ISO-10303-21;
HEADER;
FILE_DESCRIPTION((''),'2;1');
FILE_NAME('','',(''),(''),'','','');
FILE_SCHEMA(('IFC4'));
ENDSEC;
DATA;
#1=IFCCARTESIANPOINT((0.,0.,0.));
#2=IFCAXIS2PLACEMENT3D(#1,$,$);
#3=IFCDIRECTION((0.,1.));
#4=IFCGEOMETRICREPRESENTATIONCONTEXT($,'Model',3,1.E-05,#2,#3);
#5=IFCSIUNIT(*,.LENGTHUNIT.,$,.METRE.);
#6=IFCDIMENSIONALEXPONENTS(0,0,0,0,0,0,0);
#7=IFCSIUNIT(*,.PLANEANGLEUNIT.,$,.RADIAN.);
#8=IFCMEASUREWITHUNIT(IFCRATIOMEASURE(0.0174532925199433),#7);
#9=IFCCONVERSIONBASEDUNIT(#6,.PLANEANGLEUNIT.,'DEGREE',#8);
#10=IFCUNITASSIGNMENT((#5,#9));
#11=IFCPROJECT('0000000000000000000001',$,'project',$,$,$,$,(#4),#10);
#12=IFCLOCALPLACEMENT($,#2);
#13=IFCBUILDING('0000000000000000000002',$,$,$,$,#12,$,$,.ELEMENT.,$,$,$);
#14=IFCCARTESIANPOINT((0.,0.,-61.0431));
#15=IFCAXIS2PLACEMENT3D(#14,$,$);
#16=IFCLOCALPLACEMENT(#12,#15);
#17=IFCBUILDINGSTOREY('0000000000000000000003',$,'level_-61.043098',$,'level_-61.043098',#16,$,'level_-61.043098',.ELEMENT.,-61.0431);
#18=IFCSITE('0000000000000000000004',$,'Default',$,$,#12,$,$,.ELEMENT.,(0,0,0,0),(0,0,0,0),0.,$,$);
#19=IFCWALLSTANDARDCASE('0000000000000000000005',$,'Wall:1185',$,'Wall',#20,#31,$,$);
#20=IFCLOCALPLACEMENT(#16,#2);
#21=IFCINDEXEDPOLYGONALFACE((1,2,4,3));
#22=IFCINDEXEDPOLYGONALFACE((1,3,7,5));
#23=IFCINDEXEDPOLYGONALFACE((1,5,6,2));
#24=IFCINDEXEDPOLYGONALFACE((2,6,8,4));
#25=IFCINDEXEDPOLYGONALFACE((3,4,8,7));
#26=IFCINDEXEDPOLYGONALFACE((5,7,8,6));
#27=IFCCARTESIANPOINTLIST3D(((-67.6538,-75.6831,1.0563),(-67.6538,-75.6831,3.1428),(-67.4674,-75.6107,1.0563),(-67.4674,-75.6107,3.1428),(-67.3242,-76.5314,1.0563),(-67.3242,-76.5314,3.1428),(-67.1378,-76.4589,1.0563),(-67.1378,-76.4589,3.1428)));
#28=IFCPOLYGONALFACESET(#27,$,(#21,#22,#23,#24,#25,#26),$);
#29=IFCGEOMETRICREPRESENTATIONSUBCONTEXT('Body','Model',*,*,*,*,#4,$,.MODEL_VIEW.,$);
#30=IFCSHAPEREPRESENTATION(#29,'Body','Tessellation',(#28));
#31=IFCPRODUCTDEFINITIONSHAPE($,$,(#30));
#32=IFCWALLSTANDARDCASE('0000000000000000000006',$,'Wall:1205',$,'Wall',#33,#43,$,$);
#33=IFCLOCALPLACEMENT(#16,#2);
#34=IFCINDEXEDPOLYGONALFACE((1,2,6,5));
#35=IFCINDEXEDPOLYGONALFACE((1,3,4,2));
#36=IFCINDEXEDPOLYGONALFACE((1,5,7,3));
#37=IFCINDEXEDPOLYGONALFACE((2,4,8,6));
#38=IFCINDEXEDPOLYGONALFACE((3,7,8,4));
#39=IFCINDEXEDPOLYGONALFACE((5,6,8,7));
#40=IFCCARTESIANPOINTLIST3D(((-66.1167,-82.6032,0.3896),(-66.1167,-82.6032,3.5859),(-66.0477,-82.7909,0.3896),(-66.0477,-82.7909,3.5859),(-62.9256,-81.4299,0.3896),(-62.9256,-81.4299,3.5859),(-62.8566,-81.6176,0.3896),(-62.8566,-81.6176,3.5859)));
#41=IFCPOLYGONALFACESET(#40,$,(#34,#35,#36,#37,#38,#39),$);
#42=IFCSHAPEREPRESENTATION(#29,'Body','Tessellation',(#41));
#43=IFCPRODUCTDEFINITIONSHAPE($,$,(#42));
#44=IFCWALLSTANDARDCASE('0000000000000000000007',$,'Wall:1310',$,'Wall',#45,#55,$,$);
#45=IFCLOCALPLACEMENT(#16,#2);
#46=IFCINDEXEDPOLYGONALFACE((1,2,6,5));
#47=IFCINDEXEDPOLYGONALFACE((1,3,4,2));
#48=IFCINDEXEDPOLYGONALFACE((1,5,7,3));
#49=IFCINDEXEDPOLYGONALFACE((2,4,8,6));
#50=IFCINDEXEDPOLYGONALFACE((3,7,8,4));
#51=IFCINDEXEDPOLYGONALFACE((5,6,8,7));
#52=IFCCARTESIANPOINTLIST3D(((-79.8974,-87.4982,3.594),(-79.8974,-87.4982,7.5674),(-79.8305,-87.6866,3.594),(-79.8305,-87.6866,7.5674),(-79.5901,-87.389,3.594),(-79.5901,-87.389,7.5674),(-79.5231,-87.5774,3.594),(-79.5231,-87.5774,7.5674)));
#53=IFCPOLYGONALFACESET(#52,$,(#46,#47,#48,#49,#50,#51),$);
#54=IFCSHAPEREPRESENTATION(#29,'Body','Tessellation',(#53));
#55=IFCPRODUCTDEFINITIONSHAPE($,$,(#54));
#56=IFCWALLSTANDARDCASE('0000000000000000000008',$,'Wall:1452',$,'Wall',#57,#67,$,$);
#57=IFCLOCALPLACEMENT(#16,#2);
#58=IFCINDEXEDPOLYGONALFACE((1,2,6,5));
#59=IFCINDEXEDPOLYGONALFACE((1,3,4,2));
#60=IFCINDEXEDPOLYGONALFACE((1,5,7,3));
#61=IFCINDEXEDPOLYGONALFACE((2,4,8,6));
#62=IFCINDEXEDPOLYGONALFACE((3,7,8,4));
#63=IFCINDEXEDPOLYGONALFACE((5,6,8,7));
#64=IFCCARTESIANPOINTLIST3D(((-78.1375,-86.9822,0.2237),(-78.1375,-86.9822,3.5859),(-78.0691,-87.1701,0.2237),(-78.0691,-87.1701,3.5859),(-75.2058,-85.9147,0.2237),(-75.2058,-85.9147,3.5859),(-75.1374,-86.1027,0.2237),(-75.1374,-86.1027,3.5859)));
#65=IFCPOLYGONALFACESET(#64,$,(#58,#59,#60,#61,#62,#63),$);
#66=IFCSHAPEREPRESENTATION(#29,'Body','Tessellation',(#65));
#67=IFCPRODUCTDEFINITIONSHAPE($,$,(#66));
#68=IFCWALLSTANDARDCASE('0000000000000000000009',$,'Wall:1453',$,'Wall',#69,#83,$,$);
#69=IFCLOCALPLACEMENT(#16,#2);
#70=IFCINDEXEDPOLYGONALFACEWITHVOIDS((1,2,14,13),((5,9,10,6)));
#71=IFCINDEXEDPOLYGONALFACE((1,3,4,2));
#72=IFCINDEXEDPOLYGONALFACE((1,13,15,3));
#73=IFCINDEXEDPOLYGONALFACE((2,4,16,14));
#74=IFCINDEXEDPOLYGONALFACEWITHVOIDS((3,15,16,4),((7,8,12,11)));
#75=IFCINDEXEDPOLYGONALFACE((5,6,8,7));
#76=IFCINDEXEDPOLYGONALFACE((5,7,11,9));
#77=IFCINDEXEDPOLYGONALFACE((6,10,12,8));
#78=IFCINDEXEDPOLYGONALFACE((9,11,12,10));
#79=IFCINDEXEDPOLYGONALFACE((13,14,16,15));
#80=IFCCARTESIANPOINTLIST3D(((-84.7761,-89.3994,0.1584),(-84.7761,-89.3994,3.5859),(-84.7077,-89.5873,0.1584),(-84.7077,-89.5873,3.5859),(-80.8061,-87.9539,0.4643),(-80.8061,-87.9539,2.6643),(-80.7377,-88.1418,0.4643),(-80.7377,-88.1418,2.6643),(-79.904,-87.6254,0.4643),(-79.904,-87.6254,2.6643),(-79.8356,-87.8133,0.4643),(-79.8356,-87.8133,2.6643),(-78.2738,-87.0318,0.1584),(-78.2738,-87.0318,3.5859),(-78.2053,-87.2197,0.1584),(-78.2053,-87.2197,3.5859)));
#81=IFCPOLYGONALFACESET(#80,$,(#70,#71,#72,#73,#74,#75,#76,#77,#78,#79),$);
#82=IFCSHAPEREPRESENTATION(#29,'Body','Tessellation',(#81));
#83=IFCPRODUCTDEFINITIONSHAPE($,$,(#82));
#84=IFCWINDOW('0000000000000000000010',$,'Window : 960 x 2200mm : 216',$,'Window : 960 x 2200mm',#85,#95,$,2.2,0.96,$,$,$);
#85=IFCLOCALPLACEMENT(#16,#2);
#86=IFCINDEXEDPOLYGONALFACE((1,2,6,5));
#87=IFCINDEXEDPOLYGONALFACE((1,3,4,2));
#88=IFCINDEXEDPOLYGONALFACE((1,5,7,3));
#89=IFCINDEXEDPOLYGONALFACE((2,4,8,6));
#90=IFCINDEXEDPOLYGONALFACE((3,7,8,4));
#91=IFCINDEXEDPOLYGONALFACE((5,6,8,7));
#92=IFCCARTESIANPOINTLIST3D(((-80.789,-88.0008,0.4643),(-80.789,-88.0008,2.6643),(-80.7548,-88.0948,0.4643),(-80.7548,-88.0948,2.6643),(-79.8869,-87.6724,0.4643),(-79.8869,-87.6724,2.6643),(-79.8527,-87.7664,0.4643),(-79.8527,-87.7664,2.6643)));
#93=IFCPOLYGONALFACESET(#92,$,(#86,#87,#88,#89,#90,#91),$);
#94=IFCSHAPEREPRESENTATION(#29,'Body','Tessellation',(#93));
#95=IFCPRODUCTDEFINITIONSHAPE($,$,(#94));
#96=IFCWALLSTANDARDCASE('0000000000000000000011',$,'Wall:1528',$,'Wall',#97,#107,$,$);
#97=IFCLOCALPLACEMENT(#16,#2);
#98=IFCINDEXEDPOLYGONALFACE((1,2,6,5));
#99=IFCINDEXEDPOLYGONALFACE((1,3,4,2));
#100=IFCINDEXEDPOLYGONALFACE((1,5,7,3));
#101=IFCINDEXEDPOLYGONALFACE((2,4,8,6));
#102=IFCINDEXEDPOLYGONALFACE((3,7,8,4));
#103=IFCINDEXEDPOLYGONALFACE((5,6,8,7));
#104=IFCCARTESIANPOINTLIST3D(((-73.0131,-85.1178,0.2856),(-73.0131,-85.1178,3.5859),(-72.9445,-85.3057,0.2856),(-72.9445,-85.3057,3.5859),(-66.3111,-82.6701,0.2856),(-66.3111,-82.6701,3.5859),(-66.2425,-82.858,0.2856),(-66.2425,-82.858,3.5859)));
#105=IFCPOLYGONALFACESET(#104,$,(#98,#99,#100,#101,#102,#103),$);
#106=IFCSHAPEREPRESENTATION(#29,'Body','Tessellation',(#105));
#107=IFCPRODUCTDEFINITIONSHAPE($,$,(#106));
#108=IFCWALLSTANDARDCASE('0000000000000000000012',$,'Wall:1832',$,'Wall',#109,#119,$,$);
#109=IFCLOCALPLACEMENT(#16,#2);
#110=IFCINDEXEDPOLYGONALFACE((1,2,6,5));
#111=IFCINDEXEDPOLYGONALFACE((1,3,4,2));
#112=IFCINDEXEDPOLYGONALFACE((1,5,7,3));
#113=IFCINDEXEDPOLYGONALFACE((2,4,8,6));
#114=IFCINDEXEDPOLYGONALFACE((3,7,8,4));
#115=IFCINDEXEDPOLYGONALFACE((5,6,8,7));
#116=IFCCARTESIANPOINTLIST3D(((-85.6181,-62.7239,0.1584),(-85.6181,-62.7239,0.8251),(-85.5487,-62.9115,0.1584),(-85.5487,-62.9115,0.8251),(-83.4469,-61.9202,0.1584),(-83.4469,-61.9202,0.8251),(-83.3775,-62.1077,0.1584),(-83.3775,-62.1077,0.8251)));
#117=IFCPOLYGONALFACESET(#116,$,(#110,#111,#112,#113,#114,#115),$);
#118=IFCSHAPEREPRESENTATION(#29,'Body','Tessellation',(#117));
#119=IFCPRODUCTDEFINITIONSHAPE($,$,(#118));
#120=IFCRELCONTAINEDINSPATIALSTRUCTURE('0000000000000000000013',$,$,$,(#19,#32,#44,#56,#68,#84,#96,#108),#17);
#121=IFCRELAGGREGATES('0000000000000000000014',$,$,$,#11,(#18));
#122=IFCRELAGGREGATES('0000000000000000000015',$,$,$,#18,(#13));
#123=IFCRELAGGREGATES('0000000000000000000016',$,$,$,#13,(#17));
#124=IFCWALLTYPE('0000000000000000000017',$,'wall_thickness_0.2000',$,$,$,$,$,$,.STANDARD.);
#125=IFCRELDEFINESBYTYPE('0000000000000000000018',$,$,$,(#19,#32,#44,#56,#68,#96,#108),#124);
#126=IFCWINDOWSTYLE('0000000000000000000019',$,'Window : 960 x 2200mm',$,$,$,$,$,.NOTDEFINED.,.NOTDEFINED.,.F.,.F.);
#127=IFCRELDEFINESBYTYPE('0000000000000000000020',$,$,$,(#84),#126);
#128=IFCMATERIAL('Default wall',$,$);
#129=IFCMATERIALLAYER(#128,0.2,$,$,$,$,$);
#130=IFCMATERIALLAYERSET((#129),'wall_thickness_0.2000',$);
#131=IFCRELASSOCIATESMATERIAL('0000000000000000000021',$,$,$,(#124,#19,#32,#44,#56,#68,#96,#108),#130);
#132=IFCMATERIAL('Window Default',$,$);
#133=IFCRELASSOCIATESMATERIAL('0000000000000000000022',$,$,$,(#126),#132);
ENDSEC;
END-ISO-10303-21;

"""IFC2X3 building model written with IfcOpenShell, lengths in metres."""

from ifc_helpers import new_model, entity, si_unit, converted_unit, direction, frame, frame_2d, origin, origin_2d_with_axis, place, context, subcontext, project, spatial, polyline, rectangle, outline, extrude, source, transform, mapped, material, layer, layer_set, layer_usage, type_object, type_shapes, element, fill, save


model = new_model("IFC2X3")

# Units and contexts
model_context = context("Model", 3, precision=1e-05, world=origin(), true_north=direction((0.0, 1.0)))
body_context = subcontext(model_context, "Body", "Model", "MODEL_VIEW")
ifc_project = project(units=[si_unit("LENGTHUNIT", "METRE"), converted_unit("PLANEANGLEUNIT", "DEGREE", entity("IfcRatioMeasure", 0.0174532925199433), si_unit("PLANEANGLEUNIT", "RADIAN"), dimensions=[0, 0, 0, 0, 0, 0, 0])], contexts=[model_context])

# Site, building, storey
placement_1 = place(None, origin())
site = spatial("IfcSite", under=ifc_project, at=placement_1, Name="Default", CompositionType="ELEMENT", RefLatitude=(0, 0, 0, 0), RefLongitude=(0, 0, 0, 0), RefElevation=0.0)
building = spatial("IfcBuilding", under=site, at=placement_1, CompositionType="ELEMENT")
storey_placement = place(placement_1, frame((0.0, 0.0, -61.0431)))
storey = spatial("IfcBuildingStorey", under=building, at=storey_placement, Name="level_-61.043098", ObjectType="level_-61.043098", LongName="level_-61.043098", CompositionType="ELEMENT", Elevation=-61.0431)

# Shared definitions
ifc_material_1 = material(Name="Default wall")
ifc_layer = layer(ifc_material_1, 0.2)
ifc_layer_set = layer_set([ifc_layer], Name="wall_thickness_0.2000")
ifc_layer_usage = layer_usage(ifc_layer_set, "AXIS2", "POSITIVE", -0.1)
wall_type = type_object("IfcWallType", Name="wall_thickness_0.2000", PredefinedType="STANDARD", material=ifc_layer_set)

# Shared definitions
ifc_material_2 = material(Name="Window Default")

# Walls
placement_2 = place(placement_1, frame((0.0, 0.0, -59.9868)))
wall_1_placement = place(placement_2, frame((-67.231, -76.4951, 0.0), z_axis=(0.0, 0.0, 1.0), x_axis=(-0.36216, 0.932116, 0.0)))
element("IfcWallStandardCase", 1, at=wall_1_placement, inside=storey, type_object=wall_type, material=ifc_layer_usage, Name="Wall:1185", ObjectType="Wall", context=body_context, shape_type="SweptSolid", body=[
    extrude(outline(polyline([(0.91, -0.1), (0.91, 0.1), (0.0, 0.1), (0.0, -0.1), (0.91, -0.1)])), origin(), (0.0, 0.0, 1.0), 2.0865),
])
placement_3 = place(placement_1, frame((0.0, 0.0, -60.6535)))
wall_2_placement = place(placement_3, frame((-62.8911, -81.5237, 0.0), z_axis=(0.0, 0.0, 1.0), x_axis=(-0.938565, -0.345102, 0.0)))
element("IfcWallStandardCase", 2, at=wall_2_placement, inside=storey, type_object=wall_type, material=ifc_layer_usage, Name="Wall:1205", ObjectType="Wall", context=body_context, shape_type="SweptSolid", body=[
    extrude(outline(polyline([(3.4, -0.1), (3.4, 0.1), (0.0, 0.1), (0.0, -0.1), (3.4, -0.1)])), origin(), (0.0, 0.0, 1.0), 3.1963),
])
placement_4 = place(placement_1, frame((0.0, 0.0, -57.4491)))
wall_3_placement = place(placement_4, frame((-79.8639, -87.5924, 0.0), z_axis=(0.0, 0.0, 1.0), x_axis=(0.942267, 0.334862, 0.0)))
element("IfcWallStandardCase", 3, at=wall_3_placement, inside=storey, type_object=wall_type, material=ifc_layer_usage, Name="Wall:1310", ObjectType="Wall", context=body_context, shape_type="SweptSolid", body=[
    extrude(outline(polyline([(0.3261, -0.1), (0.3261, 0.1), (0.0, 0.1), (0.0, -0.1), (0.3261, -0.1)])), origin(), (0.0, 0.0, 1.0), 3.9734),
])
placement_5 = place(placement_1, frame((0.0, 0.0, -60.8194)))
wall_4_placement = place(placement_5, frame((-78.1033, -87.0762, 0.0), z_axis=(0.0, 0.0, 1.0), x_axis=(0.939651, 0.342134, 0.0)))
element("IfcWallStandardCase", 4, at=wall_4_placement, inside=storey, type_object=wall_type, material=ifc_layer_usage, Name="Wall:1452", ObjectType="Wall", context=body_context, shape_type="SweptSolid", body=[
    extrude(outline(polyline([(3.12, -0.1), (3.12, 0.1), (0.0, 0.1), (0.0, -0.1), (3.12, -0.1)])), origin(), (0.0, 0.0, 1.0), 3.3622),
])

# Wall, opening, window
placement_6 = place(placement_1, frame((0.0, 0.0, -60.8847)))
wall_5_placement = place(placement_6, frame((-84.7419, -89.4933, 0.0), z_axis=(0.0, 0.0, 1.0), x_axis=(0.939651, 0.342133, 0.0)))
wall_5 = element("IfcWallStandardCase", 5, at=wall_5_placement, inside=storey, type_object=wall_type, material=ifc_layer_usage, Name="Wall:1453", ObjectType="Wall", context=body_context, shape_type="SweptSolid", body=[
    extrude(outline(polyline([(6.92, -0.1), (6.92, 0.1), (0.0, 0.1), (0.0, -0.1), (6.92, -0.1)])), origin(), (0.0, 0.0, 1.0), 3.4275),
])
opening_1_placement = place(wall_5_placement, frame((4.225, -0.1, 0.306)))
opening_1 = element("IfcOpeningElement", 6, at=opening_1_placement, cuts=wall_5, ObjectType="Opening", context=body_context, shape_type="SweptSolid", body=[
    extrude(rectangle(XDim=0.96, YDim=2.2, at=frame_2d((1.1, 0.48), x_axis=(0.0, 1.0))), frame((0.0, 0.0, 0.0), z_axis=(0.0, 1.0, 0.0), x_axis=(0.0, 0.0, 1.0)), (0.0, 0.0, 1.0), 0.2),
])
window_style_1 = type_object("IfcWindowStyle", Name="Window : 960 x 2200mm", ConstructionType="NOTDEFINED", OperationType="NOTDEFINED", ParameterTakesPrecedence=False, Sizeable=False, material=ifc_material_2)
shared_shape_1 = source(origin(), body_context, "Body", "SweptSolid", [
    extrude(rectangle(XDim=0.1, YDim=0.96, at=origin_2d_with_axis()), frame((0.48, 0.1, 0.0), z_axis=(0.0, 0.0, 1.0), x_axis=(0.0, 1.0, 0.0)), (0.0, 0.0, 1.0), 2.2),
])
type_shapes(window_style_1, [shared_shape_1])
window_1_placement = place(opening_1_placement, origin())
window_1 = element("IfcWindow", 7, at=window_1_placement, inside=storey, type_object=window_style_1, Name="Window : 960 x 2200mm : 216", ObjectType="Window : 960 x 2200mm", OverallHeight=2.2, OverallWidth=0.96, context=body_context, shape_type="MappedRepresentation", body=[
    mapped(shared_shape_1, transform((0.0, 0.0, 0.0), scale=1.0)),
])
fill(opening_1, window_1)

# Walls
placement_7 = place(placement_1, frame((0.0, 0.0, -60.7575)))
wall_6_placement = place(placement_7, frame((-72.9788, -85.2118, 0.0), z_axis=(0.0, 0.0, 1.0), x_axis=(0.939315, 0.343055, 0.0)))
element("IfcWallStandardCase", 8, at=wall_6_placement, inside=storey, type_object=wall_type, material=ifc_layer_usage, Name="Wall:1528", ObjectType="Wall", context=body_context, shape_type="SweptSolid", body=[
    extrude(outline(polyline([(7.135, -0.1), (7.135, 0.1), (0.0, 0.1), (0.0, -0.1), (7.135, -0.1)])), origin(), (0.0, 0.0, 1.0), 3.3003),
])
placement_8 = place(placement_1, frame((0.0, 0.0, -60.8847)))
wall_7_placement = place(placement_8, frame((-85.5834, -62.8177, 0.0), z_axis=(0.0, 0.0, 1.0), x_axis=(0.937805, 0.347162, 0.0)))
element("IfcWallStandardCase", 9, at=wall_7_placement, inside=storey, type_object=wall_type, material=ifc_layer_usage, Name="Wall:1832", ObjectType="Wall", context=body_context, shape_type="SweptSolid", body=[
    extrude(outline(polyline([(2.3152, -0.1), (2.3152, 0.1), (0.0, 0.1), (0.0, -0.1), (2.3152, -0.1)])), origin(), (0.0, 0.0, 1.0), 0.6667),
])

save(model, "model.ifc")
